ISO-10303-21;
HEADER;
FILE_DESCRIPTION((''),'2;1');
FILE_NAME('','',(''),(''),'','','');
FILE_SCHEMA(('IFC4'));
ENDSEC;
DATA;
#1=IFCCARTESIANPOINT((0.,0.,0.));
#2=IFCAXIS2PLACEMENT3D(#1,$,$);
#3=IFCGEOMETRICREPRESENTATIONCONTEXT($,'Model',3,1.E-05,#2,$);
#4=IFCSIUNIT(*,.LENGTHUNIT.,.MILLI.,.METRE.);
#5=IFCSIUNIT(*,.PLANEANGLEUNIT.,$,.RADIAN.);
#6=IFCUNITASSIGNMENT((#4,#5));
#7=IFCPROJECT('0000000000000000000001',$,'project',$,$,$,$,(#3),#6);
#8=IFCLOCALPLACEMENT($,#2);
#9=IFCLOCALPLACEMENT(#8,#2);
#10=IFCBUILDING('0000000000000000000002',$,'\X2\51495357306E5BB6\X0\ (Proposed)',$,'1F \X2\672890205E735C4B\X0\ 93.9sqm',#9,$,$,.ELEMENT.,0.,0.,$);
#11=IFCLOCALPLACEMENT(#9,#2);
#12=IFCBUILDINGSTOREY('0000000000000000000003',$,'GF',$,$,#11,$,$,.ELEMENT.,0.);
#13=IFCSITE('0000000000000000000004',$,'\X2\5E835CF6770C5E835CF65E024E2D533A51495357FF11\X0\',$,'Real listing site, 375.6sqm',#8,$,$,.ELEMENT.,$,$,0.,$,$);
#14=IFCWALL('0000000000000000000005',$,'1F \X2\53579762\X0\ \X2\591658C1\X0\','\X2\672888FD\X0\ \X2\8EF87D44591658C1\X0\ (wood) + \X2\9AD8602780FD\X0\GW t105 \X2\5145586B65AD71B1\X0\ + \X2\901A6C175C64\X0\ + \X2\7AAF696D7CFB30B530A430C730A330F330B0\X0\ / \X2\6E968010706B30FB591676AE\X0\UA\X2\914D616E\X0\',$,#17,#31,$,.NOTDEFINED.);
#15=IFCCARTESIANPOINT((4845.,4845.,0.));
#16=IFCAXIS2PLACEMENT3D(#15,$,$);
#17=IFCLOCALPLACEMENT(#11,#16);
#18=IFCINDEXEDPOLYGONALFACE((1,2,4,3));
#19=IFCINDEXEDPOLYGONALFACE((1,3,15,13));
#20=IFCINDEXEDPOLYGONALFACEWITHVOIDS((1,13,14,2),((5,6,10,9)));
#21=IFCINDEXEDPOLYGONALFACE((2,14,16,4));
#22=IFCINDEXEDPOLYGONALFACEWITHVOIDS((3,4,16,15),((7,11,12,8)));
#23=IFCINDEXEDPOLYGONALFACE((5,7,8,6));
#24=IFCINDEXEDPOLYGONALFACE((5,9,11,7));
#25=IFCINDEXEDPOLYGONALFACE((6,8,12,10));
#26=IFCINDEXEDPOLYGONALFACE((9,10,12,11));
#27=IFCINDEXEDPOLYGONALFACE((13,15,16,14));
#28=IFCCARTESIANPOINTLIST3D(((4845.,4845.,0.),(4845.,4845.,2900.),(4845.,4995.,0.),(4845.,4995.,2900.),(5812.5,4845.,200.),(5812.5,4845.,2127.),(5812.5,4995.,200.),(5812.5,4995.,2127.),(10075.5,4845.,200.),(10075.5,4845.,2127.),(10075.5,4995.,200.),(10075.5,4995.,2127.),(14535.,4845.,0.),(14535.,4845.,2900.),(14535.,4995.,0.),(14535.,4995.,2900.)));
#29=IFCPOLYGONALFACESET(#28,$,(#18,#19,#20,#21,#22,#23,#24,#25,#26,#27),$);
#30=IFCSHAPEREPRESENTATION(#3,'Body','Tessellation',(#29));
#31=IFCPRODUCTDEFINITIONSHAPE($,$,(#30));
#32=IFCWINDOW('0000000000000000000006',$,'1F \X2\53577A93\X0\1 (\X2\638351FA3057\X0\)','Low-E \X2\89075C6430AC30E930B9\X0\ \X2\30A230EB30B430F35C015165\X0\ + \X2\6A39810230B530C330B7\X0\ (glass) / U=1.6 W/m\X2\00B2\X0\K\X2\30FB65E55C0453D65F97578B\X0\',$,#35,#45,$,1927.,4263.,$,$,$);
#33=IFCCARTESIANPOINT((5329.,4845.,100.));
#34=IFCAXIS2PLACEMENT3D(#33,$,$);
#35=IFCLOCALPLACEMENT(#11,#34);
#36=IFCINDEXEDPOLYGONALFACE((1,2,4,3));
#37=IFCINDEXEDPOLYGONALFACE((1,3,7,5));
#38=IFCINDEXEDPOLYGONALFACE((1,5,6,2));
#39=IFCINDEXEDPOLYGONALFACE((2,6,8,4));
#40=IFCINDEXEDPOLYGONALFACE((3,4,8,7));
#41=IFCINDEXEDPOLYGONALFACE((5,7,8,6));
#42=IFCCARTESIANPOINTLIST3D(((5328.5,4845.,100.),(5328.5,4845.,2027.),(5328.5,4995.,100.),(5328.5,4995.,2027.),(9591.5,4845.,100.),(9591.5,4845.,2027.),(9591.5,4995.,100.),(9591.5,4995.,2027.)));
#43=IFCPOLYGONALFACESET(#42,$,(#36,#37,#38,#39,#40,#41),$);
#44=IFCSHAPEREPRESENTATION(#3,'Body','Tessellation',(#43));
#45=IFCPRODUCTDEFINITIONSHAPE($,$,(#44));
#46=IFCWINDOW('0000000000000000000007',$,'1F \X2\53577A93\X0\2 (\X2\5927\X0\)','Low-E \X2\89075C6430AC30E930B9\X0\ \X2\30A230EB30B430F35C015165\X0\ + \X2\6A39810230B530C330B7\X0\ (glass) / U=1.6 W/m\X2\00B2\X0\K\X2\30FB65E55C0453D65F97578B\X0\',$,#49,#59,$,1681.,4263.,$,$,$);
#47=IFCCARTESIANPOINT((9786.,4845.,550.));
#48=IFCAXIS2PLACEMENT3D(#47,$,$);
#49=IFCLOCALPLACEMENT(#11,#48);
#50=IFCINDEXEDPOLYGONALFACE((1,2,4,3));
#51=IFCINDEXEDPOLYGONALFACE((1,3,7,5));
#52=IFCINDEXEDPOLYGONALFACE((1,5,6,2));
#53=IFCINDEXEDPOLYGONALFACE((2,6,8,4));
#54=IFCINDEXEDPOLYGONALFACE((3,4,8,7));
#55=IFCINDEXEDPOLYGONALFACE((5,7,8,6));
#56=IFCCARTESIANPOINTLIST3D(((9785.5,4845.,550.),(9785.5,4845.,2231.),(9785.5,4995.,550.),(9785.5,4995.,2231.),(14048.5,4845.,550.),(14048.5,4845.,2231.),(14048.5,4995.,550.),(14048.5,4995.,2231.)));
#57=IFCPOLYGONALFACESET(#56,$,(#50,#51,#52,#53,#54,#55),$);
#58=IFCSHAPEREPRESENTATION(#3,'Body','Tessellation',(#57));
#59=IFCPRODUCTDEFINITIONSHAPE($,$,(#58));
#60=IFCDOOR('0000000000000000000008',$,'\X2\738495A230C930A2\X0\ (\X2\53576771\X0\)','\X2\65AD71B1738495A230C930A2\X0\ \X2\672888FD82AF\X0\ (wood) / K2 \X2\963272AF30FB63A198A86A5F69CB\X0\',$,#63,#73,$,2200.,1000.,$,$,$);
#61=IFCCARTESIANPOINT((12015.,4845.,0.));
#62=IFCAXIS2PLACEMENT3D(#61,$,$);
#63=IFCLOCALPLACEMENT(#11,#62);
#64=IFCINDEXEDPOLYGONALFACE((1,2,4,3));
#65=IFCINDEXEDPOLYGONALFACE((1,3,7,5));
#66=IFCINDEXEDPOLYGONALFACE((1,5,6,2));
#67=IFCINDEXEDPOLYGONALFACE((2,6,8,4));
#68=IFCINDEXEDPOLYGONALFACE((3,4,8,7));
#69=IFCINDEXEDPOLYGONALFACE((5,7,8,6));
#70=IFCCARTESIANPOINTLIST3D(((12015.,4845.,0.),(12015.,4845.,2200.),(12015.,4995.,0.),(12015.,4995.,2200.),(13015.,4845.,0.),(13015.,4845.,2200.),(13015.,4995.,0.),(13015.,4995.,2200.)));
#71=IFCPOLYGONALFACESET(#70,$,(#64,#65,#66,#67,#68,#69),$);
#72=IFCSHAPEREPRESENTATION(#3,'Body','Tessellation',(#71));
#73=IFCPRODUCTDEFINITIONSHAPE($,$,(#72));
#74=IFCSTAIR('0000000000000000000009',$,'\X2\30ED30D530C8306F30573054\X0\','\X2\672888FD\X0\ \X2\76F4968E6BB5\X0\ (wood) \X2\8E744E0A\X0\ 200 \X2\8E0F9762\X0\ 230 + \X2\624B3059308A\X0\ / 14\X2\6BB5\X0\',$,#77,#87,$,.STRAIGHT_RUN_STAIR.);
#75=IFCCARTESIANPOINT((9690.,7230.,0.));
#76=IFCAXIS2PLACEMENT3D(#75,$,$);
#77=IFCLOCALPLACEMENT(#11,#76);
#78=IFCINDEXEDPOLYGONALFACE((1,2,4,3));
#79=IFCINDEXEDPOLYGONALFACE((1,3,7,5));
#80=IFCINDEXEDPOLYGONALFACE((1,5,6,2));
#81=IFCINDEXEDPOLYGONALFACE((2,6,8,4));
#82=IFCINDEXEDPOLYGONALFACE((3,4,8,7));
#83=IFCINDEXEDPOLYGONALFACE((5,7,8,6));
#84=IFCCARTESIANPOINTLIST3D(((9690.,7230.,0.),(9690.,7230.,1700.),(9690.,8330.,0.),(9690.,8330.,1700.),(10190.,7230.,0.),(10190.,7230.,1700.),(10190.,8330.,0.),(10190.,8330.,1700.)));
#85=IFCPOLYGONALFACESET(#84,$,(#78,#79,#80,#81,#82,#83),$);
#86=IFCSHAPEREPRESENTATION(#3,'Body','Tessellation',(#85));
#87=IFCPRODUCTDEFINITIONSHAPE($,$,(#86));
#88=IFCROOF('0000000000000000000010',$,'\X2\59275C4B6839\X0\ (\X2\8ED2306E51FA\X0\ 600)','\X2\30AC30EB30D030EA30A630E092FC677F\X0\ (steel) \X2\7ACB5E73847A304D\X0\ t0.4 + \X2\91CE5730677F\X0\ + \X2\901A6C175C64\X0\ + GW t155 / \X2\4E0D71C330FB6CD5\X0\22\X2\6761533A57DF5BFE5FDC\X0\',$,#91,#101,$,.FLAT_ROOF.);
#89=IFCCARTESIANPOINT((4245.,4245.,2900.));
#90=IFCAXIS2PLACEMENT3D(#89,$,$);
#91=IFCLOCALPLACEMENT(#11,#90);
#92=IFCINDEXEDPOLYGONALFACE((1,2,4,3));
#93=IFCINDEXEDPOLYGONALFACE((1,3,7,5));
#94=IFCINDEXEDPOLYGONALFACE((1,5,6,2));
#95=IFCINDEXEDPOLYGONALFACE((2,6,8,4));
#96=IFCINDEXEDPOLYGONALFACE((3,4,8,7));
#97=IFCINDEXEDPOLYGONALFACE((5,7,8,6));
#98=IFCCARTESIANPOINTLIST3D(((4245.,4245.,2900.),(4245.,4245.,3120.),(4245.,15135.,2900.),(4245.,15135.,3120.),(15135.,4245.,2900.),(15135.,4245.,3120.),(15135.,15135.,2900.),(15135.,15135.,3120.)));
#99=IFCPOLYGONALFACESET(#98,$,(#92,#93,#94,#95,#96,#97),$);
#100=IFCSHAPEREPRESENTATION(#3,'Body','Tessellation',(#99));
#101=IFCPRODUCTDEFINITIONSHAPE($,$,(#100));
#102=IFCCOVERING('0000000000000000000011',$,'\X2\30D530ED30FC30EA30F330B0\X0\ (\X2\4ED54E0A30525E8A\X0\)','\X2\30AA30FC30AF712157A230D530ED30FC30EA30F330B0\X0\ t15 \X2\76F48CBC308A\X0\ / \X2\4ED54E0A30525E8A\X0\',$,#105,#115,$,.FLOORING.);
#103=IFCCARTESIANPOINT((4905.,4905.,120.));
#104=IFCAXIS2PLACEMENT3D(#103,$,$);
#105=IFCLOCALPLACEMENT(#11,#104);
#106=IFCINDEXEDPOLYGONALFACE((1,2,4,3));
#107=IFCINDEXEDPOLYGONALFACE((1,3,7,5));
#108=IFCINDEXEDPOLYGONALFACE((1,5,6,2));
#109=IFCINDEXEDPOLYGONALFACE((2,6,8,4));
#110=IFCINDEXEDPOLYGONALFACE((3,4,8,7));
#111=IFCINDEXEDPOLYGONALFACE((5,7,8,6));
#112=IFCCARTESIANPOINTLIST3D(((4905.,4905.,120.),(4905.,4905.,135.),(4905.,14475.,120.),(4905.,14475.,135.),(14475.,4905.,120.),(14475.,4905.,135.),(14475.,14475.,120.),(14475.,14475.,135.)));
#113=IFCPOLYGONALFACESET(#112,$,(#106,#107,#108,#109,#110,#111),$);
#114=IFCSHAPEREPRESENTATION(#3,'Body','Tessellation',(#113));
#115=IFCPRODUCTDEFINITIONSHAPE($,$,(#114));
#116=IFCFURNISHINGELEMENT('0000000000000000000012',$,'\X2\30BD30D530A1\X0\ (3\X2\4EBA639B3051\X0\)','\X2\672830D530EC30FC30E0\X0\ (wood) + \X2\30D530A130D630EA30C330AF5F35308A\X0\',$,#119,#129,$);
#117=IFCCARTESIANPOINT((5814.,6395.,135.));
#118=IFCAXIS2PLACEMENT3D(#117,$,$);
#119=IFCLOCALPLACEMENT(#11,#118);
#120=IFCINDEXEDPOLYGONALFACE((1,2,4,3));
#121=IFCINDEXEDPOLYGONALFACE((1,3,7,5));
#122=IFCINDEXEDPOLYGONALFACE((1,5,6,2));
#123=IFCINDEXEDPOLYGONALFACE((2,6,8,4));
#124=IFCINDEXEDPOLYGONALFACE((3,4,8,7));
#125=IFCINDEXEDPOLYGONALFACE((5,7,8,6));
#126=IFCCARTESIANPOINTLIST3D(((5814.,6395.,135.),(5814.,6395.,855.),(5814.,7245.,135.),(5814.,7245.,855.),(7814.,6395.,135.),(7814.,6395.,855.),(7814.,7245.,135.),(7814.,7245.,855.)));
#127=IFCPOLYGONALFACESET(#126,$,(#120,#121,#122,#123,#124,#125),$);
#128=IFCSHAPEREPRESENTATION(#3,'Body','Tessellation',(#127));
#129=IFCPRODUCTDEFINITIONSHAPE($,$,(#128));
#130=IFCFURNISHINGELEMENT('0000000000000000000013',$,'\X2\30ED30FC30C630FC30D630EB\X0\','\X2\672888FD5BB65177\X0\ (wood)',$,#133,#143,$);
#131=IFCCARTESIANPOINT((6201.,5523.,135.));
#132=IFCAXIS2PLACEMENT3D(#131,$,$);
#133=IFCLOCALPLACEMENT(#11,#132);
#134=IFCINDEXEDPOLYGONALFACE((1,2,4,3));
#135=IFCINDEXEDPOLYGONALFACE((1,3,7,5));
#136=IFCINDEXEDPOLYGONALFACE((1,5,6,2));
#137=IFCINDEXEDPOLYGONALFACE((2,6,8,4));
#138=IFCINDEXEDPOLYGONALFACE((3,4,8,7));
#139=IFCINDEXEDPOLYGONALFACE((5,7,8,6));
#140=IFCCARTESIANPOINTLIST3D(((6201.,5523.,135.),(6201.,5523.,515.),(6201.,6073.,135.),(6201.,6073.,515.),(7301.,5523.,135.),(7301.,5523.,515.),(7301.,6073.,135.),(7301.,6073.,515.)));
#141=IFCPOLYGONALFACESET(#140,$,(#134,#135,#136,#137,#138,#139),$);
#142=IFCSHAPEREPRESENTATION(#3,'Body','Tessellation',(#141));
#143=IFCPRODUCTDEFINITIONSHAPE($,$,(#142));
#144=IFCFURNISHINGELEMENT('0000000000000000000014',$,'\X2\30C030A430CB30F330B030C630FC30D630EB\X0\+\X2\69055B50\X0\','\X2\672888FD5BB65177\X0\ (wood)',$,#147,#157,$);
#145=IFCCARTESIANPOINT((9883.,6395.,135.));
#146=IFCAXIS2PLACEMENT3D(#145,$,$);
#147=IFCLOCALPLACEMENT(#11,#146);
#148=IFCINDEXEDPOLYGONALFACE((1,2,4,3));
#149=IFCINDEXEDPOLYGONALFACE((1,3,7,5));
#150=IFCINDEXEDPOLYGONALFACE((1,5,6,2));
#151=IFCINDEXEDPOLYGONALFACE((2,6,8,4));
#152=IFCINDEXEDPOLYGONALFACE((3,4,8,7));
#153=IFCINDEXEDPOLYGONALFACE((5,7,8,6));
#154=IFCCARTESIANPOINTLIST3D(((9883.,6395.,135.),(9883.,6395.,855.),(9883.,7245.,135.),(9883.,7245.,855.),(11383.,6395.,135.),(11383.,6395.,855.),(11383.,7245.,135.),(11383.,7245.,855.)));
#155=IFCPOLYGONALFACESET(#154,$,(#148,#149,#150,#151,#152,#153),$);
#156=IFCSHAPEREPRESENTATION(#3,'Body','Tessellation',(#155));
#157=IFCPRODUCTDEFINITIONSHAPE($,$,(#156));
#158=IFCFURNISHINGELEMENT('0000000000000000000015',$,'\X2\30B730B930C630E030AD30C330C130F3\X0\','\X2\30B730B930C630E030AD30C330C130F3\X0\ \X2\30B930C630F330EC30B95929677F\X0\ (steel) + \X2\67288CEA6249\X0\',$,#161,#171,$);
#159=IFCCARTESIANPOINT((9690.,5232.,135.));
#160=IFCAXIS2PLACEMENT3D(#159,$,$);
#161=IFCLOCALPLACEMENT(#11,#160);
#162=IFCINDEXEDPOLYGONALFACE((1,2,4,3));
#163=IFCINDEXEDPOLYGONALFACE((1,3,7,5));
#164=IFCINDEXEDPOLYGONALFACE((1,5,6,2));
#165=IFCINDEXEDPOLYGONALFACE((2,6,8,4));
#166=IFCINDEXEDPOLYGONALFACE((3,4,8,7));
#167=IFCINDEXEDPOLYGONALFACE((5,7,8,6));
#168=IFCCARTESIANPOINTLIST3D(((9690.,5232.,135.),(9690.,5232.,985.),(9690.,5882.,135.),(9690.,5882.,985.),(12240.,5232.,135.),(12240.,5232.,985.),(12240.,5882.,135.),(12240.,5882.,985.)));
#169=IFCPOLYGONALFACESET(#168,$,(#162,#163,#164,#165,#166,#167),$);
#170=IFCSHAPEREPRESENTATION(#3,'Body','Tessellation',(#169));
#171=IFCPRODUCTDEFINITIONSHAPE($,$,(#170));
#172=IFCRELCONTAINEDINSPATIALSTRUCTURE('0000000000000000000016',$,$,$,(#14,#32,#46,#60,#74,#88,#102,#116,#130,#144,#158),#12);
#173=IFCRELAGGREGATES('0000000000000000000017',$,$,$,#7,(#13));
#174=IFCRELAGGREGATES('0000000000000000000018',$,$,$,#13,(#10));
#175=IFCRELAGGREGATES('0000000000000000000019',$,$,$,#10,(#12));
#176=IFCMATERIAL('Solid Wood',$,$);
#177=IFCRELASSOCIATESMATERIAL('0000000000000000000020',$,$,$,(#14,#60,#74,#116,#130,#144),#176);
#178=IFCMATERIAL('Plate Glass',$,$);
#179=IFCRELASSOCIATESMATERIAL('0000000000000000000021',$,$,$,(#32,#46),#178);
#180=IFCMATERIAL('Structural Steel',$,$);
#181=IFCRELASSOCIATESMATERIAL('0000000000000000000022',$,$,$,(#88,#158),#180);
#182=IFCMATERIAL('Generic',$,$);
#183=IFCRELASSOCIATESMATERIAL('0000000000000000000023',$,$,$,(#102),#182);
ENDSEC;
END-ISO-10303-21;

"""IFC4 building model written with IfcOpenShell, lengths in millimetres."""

from ifc_helpers import new_model, si_unit, frame, frame_2d, origin, place, context, project, spatial, rectangle, extrude, material, element, fill, save


model = new_model("IFC4")

# Units and contexts
model_context = context("Model", 3, precision=1e-05, world=origin())
ifc_project = project(units=[si_unit("LENGTHUNIT", "METRE", prefix="MILLI"), si_unit("PLANEANGLEUNIT", "RADIAN")], contexts=[model_context])

# Site, building, storey
site_placement = place(None, origin())
site = spatial("IfcSite", under=ifc_project, at=site_placement, Name="広島県広島市中区光南１", ObjectType="Real listing site, 375.6sqm", CompositionType="ELEMENT", RefElevation=0.0)
building_placement = place(site_placement, origin())
building = spatial("IfcBuilding", under=site, at=building_placement, Name="光南の家 (Proposed)", ObjectType="1F 木造平屋 93.9sqm", CompositionType="ELEMENT", ElevationOfRefHeight=0.0, ElevationOfTerrain=0.0)
storey_placement = place(building_placement, origin())
storey = spatial("IfcBuildingStorey", under=building, at=storey_placement, Name="GF", CompositionType="ELEMENT", Elevation=0.0)

# Shared definitions
ifc_material_1 = material(Name="Solid Wood")

# Wall, openings, windows, door
wall_1_placement = place(storey_placement, frame((4845.0, 4845.0, 0.0)))
wall_1 = element("IfcWall", 1, at=wall_1_placement, inside=storey, material=ifc_material_1, Name="1F 南面 外壁", Description="木製 軸組外壁 (wood) + 高性能GW t105 充填断熱 + 通気層 + 窯業系サイディング / 準耐火・外皮UA配慮", PredefinedType="NOTDEFINED", context=model_context, shape_type="SweptSolid", body=[
    extrude(rectangle(XDim=9690.0, YDim=150.0, at=frame_2d((4845.0, 75.0))), frame((4845.0, 4845.0, 0.0)), (0.0, 0.0, 1.0), 2900.0),
])
opening_1_placement = place(storey_placement, frame((5329.0, 4845.0, 100.0)))
opening_1 = element("IfcOpeningElement", 2, at=opening_1_placement, cuts=wall_1, PredefinedType="NOTDEFINED", context=model_context, shape_type="SweptSolid", body=[
    extrude(rectangle(XDim=4263.0, YDim=150.0, at=frame_2d((2131.0, 75.0))), frame((5329.0, 4845.0, 100.0)), (0.0, 0.0, 1.0), 1927.0),
])
opening_2_placement = place(storey_placement, frame((9786.0, 4845.0, 550.0)))
opening_2 = element("IfcOpeningElement", 3, at=opening_2_placement, cuts=wall_1, PredefinedType="NOTDEFINED", context=model_context, shape_type="SweptSolid", body=[
    extrude(rectangle(XDim=4263.0, YDim=150.0, at=frame_2d((2131.0, 75.0))), frame((9786.0, 4845.0, 550.0)), (0.0, 0.0, 1.0), 1681.0),
])
opening_3_placement = place(storey_placement, frame((12015.0, 4845.0, 0.0)))
opening_3 = element("IfcOpeningElement", 4, at=opening_3_placement, cuts=wall_1, PredefinedType="NOTDEFINED", context=model_context, shape_type="SweptSolid", body=[
    extrude(rectangle(XDim=1000.0, YDim=150.0, at=frame_2d((500.0, 75.0))), frame((12015.0, 4845.0, 0.0)), (0.0, 0.0, 1.0), 2200.0),
])
ifc_material_2 = material(Name="Plate Glass")
window_1_placement = place(storey_placement, frame((5329.0, 4845.0, 100.0)))
window_1 = element("IfcWindow", 5, at=window_1_placement, inside=storey, material=ifc_material_2, Name="1F 南窓1 (掃出し)", Description="Low-E 複層ガラス アルゴン封入 + 樹脂サッシ (glass) / U=1.6 W/m²K・日射取得型", OverallHeight=1927.0, OverallWidth=4263.0, context=model_context, shape_type="SweptSolid", body=[
    extrude(rectangle(XDim=4263.0, YDim=150.0, at=frame_2d((2131.0, 75.0))), frame((5329.0, 4845.0, 100.0)), (0.0, 0.0, 1.0), 1927.0),
])
fill(opening_1, window_1)
window_2_placement = place(storey_placement, frame((9786.0, 4845.0, 550.0)))
window_2 = element("IfcWindow", 6, at=window_2_placement, inside=storey, material=ifc_material_2, Name="1F 南窓2 (大)", Description="Low-E 複層ガラス アルゴン封入 + 樹脂サッシ (glass) / U=1.6 W/m²K・日射取得型", OverallHeight=1681.0, OverallWidth=4263.0, context=model_context, shape_type="SweptSolid", body=[
    extrude(rectangle(XDim=4263.0, YDim=150.0, at=frame_2d((2131.0, 75.0))), frame((9786.0, 4845.0, 550.0)), (0.0, 0.0, 1.0), 1681.0),
])
fill(opening_2, window_2)
door_placement = place(storey_placement, frame((12015.0, 4845.0, 0.0)))
door = element("IfcDoor", 7, at=door_placement, inside=storey, material=ifc_material_1, Name="玄関ドア (南東)", Description="断熱玄関ドア 木製芯 (wood) / K2 防犯・採風機構", OverallHeight=2200.0, OverallWidth=1000.0, context=model_context, shape_type="SweptSolid", body=[
    extrude(rectangle(XDim=1000.0, YDim=150.0, at=frame_2d((500.0, 75.0))), frame((12015.0, 4845.0, 0.0)), (0.0, 0.0, 1.0), 2200.0),
])
fill(opening_3, door)

# Stair
stair_placement = place(storey_placement, frame((9690.0, 7230.0, 0.0)))
element("IfcStair", 8, at=stair_placement, inside=storey, material=ifc_material_1, Name="ロフトはしご", Description="木製 直階段 (wood) 蹴上 200 踏面 230 + 手すり / 14段", PredefinedType="STRAIGHT_RUN_STAIR", context=model_context, shape_type="SweptSolid", body=[
    extrude(rectangle(XDim=500.0, YDim=1100.0, at=frame_2d((250.0, 550.0))), frame((9690.0, 7230.0, 0.0)), (0.0, 0.0, 1.0), 1700.0),
])

# Roof
ifc_material_3 = material(Name="Structural Steel")
roof_placement = place(storey_placement, frame((4245.0, 4245.0, 2900.0)))
element("IfcRoof", 9, at=roof_placement, inside=storey, material=ifc_material_3, Name="大屋根 (軒の出 600)", Description="ガルバリウム鋼板 (steel) 立平葺き t0.4 + 野地板 + 通気層 + GW t155 / 不燃・法22条区域対応", PredefinedType="FLAT_ROOF", context=model_context, shape_type="SweptSolid", body=[
    extrude(rectangle(XDim=10890.0, YDim=10890.0, at=frame_2d((5445.0, 5445.0))), frame((4245.0, 4245.0, 2900.0)), (0.0, 0.0, 1.0), 220.0),
])

# Covering
ifc_material_4 = material(Name="Generic")
covering_placement = place(storey_placement, frame((4905.0, 4905.0, 120.0)))
element("IfcCovering", 10, at=covering_placement, inside=storey, material=ifc_material_4, Name="フローリング (仕上げ床)", Description="オーク無垢フローリング t15 直貼り / 仕上げ床", PredefinedType="FLOORING", context=model_context, shape_type="SweptSolid", body=[
    extrude(rectangle(XDim=9570.0, YDim=9570.0, at=frame_2d((4785.0, 4785.0))), frame((4905.0, 4905.0, 120.0)), (0.0, 0.0, 1.0), 15.0),
])

# Furnishing elements
furnishing_1_placement = place(storey_placement, frame((5814.0, 6395.0, 135.0)))
element("IfcFurnishingElement", 11, at=furnishing_1_placement, inside=storey, material=ifc_material_1, Name="ソファ (3人掛け)", Description="木フレーム (wood) + ファブリック張り", context=model_context, shape_type="SweptSolid", body=[
    extrude(rectangle(XDim=2000.0, YDim=850.0, at=frame_2d((1000.0, 425.0))), frame((5814.0, 6395.0, 135.0)), (0.0, 0.0, 1.0), 720.0),
])
furnishing_2_placement = place(storey_placement, frame((6201.0, 5523.0, 135.0)))
element("IfcFurnishingElement", 12, at=furnishing_2_placement, inside=storey, material=ifc_material_1, Name="ローテーブル", Description="木製家具 (wood)", context=model_context, shape_type="SweptSolid", body=[
    extrude(rectangle(XDim=1100.0, YDim=550.0, at=frame_2d((550.0, 275.0))), frame((6201.0, 5523.0, 135.0)), (0.0, 0.0, 1.0), 380.0),
])
furnishing_3_placement = place(storey_placement, frame((9883.0, 6395.0, 135.0)))
element("IfcFurnishingElement", 13, at=furnishing_3_placement, inside=storey, material=ifc_material_1, Name="ダイニングテーブル+椅子", Description="木製家具 (wood)", context=model_context, shape_type="SweptSolid", body=[
    extrude(rectangle(XDim=1500.0, YDim=850.0, at=frame_2d((750.0, 425.0))), frame((9883.0, 6395.0, 135.0)), (0.0, 0.0, 1.0), 720.0),
])
furnishing_4_placement = place(storey_placement, frame((9690.0, 5232.0, 135.0)))
element("IfcFurnishingElement", 14, at=furnishing_4_placement, inside=storey, material=ifc_material_3, Name="システムキッチン", Description="システムキッチン ステンレス天板 (steel) + 木質扉", context=model_context, shape_type="SweptSolid", body=[
    extrude(rectangle(XDim=2550.0, YDim=650.0, at=frame_2d((1275.0, 325.0))), frame((9690.0, 5232.0, 135.0)), (0.0, 0.0, 1.0), 850.0),
])

save(model, "model.ifc")
